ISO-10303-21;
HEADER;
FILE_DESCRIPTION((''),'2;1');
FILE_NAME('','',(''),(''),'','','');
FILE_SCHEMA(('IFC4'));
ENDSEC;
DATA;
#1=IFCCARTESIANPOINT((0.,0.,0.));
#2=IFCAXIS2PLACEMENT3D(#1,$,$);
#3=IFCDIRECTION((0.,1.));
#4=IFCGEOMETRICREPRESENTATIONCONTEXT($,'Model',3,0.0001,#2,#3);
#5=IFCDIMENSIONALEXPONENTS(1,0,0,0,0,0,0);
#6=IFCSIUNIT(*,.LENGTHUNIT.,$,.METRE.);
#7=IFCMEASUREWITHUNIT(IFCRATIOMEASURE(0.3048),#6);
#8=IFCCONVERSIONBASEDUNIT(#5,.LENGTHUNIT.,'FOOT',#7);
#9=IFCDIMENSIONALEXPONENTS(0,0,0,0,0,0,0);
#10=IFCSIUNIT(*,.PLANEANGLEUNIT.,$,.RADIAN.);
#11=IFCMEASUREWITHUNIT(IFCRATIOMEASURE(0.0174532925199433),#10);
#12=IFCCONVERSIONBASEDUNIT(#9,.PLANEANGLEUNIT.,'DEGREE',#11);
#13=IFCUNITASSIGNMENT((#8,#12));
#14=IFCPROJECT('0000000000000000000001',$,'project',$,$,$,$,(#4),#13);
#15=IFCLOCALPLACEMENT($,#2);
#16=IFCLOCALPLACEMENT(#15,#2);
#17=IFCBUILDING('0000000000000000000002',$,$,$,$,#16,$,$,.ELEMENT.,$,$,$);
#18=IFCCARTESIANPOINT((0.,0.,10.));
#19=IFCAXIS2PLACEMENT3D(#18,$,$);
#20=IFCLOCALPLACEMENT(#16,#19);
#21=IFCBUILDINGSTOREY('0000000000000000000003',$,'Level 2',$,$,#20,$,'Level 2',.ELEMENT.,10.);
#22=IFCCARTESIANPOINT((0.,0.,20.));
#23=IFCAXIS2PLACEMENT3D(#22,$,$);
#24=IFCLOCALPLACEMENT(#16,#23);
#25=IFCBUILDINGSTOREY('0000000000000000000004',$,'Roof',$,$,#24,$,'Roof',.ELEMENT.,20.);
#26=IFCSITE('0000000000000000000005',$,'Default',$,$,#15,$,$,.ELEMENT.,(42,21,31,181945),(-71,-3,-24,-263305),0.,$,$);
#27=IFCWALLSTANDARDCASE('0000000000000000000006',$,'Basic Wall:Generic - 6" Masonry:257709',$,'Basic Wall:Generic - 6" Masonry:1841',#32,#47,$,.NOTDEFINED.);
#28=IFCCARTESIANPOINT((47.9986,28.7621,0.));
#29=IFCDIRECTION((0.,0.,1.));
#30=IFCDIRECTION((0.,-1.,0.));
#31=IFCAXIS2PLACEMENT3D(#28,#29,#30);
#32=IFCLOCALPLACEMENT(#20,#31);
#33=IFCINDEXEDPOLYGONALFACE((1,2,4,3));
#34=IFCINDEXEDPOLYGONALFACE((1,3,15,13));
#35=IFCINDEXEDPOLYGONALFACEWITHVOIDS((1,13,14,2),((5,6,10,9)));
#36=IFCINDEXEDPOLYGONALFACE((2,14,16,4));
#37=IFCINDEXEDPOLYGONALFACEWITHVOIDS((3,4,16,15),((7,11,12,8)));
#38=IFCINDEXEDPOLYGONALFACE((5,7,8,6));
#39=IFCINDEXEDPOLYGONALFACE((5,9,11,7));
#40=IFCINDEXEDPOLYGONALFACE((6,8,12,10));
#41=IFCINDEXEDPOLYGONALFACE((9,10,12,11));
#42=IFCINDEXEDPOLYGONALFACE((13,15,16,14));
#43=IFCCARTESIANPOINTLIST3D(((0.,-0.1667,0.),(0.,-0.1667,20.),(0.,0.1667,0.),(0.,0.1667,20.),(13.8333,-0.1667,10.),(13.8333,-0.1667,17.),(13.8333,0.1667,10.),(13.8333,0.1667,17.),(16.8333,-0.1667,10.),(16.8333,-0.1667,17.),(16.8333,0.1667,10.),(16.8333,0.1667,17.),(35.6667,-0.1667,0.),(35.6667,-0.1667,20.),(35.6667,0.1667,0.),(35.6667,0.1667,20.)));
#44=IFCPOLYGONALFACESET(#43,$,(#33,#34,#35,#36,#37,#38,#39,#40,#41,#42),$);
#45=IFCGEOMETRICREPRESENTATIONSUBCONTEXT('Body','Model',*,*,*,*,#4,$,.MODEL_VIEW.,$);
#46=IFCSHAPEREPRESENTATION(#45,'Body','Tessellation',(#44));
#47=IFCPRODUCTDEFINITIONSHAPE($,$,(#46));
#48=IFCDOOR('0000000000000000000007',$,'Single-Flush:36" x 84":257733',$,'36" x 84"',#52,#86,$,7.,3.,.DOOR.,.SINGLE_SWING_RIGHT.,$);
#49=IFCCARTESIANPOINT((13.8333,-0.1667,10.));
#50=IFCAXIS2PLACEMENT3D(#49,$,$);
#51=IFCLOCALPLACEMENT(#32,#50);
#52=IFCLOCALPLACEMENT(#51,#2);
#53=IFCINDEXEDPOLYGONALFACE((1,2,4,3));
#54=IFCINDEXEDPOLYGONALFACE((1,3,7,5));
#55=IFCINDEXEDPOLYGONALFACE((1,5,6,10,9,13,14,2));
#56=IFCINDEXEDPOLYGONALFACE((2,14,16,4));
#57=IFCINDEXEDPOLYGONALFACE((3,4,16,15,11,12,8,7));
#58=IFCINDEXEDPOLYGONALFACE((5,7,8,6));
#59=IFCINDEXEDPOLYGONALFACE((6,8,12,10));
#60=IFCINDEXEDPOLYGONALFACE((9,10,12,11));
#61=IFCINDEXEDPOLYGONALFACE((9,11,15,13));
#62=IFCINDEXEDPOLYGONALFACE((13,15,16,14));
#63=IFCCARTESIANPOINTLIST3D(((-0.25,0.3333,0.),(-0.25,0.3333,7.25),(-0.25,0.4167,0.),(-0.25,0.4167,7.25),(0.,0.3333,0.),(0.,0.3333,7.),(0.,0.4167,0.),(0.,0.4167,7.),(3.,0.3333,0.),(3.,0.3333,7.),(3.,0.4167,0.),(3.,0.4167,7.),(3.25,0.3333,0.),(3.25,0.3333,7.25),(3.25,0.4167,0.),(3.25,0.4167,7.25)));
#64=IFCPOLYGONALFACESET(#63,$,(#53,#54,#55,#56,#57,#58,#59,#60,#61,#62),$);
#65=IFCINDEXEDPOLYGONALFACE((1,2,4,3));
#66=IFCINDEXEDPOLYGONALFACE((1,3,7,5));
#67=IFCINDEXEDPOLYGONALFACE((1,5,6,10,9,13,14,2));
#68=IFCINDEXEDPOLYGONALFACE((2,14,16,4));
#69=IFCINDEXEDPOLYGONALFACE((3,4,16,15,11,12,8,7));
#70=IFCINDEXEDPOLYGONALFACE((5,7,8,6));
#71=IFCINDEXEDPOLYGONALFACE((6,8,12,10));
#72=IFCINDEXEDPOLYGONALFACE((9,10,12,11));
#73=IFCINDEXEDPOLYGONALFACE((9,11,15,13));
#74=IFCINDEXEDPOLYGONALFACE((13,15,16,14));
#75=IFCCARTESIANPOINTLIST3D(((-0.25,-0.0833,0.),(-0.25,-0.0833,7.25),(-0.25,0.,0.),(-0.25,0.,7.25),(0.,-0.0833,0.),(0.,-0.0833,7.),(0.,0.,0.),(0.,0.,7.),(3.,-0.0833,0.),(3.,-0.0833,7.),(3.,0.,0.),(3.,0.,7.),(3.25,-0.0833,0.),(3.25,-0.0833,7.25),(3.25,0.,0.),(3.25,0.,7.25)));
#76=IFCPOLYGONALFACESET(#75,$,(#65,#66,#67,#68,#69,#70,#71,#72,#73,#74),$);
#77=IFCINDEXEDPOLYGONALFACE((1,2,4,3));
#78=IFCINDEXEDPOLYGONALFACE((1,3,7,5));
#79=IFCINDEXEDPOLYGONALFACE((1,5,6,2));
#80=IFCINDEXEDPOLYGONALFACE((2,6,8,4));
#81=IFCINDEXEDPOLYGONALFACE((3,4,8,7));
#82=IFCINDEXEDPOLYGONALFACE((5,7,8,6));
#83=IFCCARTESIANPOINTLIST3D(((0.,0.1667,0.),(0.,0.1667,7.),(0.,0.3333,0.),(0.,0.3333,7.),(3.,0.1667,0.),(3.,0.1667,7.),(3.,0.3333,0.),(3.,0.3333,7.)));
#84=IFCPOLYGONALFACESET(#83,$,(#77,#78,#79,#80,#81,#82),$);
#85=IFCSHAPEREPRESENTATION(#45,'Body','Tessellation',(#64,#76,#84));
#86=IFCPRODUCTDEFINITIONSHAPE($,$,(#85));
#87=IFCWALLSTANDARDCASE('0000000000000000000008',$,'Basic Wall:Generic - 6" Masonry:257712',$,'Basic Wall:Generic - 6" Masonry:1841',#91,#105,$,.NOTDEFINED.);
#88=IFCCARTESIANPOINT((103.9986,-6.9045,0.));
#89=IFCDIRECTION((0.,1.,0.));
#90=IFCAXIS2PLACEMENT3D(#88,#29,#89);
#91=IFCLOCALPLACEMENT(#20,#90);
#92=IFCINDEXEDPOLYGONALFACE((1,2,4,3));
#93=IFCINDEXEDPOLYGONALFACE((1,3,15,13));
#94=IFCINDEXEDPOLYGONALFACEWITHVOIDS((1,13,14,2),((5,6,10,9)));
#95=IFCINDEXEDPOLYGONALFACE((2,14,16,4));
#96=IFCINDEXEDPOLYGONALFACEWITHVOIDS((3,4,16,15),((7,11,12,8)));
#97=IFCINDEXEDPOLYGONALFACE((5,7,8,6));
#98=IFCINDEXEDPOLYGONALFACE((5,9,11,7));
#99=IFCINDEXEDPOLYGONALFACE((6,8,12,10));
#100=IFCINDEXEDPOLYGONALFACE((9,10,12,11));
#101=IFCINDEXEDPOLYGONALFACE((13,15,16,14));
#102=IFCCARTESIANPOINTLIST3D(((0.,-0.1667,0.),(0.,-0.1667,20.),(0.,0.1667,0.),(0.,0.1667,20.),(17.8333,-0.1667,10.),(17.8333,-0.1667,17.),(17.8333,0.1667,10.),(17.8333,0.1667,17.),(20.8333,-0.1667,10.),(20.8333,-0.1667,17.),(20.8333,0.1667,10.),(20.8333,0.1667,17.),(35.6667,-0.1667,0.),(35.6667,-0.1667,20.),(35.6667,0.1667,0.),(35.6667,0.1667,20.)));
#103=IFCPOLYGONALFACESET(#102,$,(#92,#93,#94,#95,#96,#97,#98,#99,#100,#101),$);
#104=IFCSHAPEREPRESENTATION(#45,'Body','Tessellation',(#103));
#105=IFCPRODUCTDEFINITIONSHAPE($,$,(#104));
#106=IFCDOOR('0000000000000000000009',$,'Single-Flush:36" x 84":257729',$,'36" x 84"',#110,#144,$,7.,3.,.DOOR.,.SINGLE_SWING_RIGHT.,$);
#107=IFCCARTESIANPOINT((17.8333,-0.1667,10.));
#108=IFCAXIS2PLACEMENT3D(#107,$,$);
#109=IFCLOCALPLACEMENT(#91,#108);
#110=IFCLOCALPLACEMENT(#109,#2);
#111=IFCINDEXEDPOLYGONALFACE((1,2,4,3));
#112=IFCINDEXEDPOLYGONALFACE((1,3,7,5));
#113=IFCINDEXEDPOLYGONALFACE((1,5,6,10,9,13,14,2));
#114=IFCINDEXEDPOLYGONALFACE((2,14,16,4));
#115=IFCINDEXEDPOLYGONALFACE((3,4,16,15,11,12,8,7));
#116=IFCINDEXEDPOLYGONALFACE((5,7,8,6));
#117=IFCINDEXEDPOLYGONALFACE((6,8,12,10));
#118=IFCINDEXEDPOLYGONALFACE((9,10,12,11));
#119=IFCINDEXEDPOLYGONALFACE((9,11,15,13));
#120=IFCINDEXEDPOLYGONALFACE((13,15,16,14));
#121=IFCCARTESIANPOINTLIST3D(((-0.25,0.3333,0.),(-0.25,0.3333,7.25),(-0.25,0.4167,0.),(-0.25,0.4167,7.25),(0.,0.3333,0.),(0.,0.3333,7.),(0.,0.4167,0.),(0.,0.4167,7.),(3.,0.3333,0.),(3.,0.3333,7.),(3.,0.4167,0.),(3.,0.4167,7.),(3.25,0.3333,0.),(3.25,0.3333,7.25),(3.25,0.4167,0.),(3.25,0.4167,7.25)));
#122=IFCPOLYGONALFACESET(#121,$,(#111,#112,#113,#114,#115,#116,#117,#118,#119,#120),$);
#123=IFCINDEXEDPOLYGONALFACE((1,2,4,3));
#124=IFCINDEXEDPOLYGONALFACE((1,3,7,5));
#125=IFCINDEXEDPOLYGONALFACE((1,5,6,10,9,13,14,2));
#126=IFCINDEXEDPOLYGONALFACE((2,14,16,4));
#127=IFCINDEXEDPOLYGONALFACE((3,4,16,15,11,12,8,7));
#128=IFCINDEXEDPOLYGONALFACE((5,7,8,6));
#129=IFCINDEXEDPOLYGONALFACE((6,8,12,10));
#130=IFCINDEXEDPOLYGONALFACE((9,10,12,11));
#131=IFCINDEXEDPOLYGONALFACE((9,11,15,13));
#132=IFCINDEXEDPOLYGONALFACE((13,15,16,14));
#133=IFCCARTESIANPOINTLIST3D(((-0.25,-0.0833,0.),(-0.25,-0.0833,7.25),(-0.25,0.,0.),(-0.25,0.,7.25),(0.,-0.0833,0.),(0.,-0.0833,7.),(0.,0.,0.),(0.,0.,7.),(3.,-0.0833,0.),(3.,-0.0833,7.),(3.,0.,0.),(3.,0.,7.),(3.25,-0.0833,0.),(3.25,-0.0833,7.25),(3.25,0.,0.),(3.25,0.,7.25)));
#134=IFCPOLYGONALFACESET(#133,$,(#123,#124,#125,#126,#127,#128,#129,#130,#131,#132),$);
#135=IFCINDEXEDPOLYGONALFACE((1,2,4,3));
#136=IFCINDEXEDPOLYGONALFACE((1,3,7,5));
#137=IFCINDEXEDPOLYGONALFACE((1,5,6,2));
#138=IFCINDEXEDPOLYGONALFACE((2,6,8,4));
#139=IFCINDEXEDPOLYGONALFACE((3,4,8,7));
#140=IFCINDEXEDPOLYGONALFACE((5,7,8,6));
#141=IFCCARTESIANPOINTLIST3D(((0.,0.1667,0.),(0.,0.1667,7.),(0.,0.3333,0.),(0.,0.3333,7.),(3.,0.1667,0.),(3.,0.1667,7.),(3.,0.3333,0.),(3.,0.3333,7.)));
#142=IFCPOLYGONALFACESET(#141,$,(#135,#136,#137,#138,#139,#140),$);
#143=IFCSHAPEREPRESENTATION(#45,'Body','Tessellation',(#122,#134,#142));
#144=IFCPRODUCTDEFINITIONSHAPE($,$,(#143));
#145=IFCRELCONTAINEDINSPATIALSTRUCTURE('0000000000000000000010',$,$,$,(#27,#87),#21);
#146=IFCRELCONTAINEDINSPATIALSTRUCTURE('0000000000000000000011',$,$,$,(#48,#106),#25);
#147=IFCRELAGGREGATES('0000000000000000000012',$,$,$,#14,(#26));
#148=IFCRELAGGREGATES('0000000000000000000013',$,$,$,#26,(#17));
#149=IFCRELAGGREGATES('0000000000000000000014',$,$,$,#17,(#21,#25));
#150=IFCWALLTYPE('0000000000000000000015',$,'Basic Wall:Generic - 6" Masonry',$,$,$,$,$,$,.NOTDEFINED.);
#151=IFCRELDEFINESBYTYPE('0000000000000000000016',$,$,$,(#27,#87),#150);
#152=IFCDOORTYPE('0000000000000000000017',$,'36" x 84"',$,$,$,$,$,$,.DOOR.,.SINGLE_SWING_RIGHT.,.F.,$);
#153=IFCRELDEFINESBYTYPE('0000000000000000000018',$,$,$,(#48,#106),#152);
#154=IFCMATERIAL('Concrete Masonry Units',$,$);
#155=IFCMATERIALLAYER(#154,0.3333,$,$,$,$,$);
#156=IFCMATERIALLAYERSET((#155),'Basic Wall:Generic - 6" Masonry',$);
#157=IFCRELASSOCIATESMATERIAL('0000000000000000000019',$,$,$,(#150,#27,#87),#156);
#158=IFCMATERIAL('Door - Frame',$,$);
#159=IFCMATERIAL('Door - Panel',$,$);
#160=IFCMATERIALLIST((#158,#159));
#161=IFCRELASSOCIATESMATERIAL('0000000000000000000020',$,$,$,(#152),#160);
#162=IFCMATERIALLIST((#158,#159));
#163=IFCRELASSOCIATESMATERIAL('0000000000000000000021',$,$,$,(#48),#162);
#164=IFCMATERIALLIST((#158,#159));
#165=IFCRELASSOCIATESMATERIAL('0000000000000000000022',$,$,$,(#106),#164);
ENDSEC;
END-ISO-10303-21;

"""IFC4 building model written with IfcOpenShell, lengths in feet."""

from ifc_helpers import new_model, entity, si_unit, converted_unit, direction, frame, frame_2d, origin, place, context, subcontext, project, spatial, polyline, rectangle, outline, extrude, source, transform, mapped, material, material_list, layer, layer_set, layer_usage, type_object, type_shapes, element, fill, save


model = new_model("IFC4")

# Units and contexts
model_context = context("Model", 3, precision=0.0001, world=origin(), true_north=direction((0.0, 1.0)))
body_context = subcontext(model_context, "Body", "Model", "MODEL_VIEW")
ifc_project = project(units=[converted_unit("LENGTHUNIT", "FOOT", entity("IfcRatioMeasure", 0.3048), si_unit("LENGTHUNIT", "METRE"), dimensions=[1, 0, 0, 0, 0, 0, 0]), converted_unit("PLANEANGLEUNIT", "DEGREE", entity("IfcRatioMeasure", 0.0174532925199433), si_unit("PLANEANGLEUNIT", "RADIAN"), dimensions=[0, 0, 0, 0, 0, 0, 0])], contexts=[model_context])

# Site, building, storey
site_placement = place(None, origin())
site = spatial("IfcSite", under=ifc_project, at=site_placement, Name="Default", CompositionType="ELEMENT", RefLatitude=(42, 21, 31, 181945), RefLongitude=(-71, -3, -24, -263305), RefElevation=0.0)
building_placement = place(site_placement, origin())
building = spatial("IfcBuilding", under=site, at=building_placement, CompositionType="ELEMENT")
storey_1_placement = place(building_placement, frame((0.0, 0.0, 10.0)))
storey_1 = spatial("IfcBuildingStorey", under=building, at=storey_1_placement, Name="Level 2", LongName="Level 2", CompositionType="ELEMENT", Elevation=10.0)

# Wall, opening
ifc_material_1 = material(Name="Concrete Masonry Units")
ifc_layer = layer(ifc_material_1, 0.3333)
ifc_layer_set = layer_set([ifc_layer], Name="Basic Wall:Generic - 6\" Masonry")
ifc_layer_usage_1 = layer_usage(ifc_layer_set, "AXIS2", "NEGATIVE", 0.1667)
wall_type = type_object("IfcWallType", Name="Basic Wall:Generic - 6\" Masonry", PredefinedType="NOTDEFINED", material=ifc_layer_set)
wall_1_placement = place(storey_1_placement, frame((47.9986, 28.7621, 0.0), z_axis=(0.0, 0.0, 1.0), x_axis=(0.0, -1.0, 0.0)))
wall_1 = element("IfcWallStandardCase", 1, at=wall_1_placement, inside=storey_1, type_object=wall_type, material=ifc_layer_usage_1, Name="Basic Wall:Generic - 6\" Masonry:257709", ObjectType="Basic Wall:Generic - 6\" Masonry:1841", PredefinedType="NOTDEFINED", context=body_context, shape_type="SweptSolid", body=[
    extrude(rectangle(XDim=35.6667, YDim=0.3333, at=frame_2d((17.8333, 0.0), x_axis=(-1.0, 0.0))), origin(), (0.0, 0.0, 1.0), 20.0),
])
opening_1_placement = place(wall_1_placement, frame((13.8333, -0.1667, 10.0)))
opening_1 = element("IfcOpeningElement", 2, at=opening_1_placement, cuts=wall_1, ObjectType="Opening", PredefinedType="OPENING", context=body_context, shape_type="SweptSolid", body=[
    extrude(rectangle(XDim=3.0, YDim=7.0, at=frame_2d((3.5, 1.5), x_axis=(0.0, 1.0))), frame((0.0, 0.0, 0.0), z_axis=(0.0, 1.0, 0.0), x_axis=(0.0, 0.0, 1.0)), (0.0, 0.0, 1.0), 0.3333),
])

# Shared definitions
storey_2_placement = place(building_placement, frame((0.0, 0.0, 20.0)))
storey_2 = spatial("IfcBuildingStorey", under=building, at=storey_2_placement, Name="Roof", LongName="Roof", CompositionType="ELEMENT", Elevation=20.0)

# Door
ifc_material_2 = material(Name="Door - Frame")
ifc_material_3 = material(Name="Door - Panel")
ifc_material_list_1 = material_list([ifc_material_2, ifc_material_3])
ifc_material_list_2 = material_list([ifc_material_2, ifc_material_3])
door_type = type_object("IfcDoorType", Name="36\" x 84\"", OperationType="SINGLE_SWING_RIGHT", ParameterTakesPrecedence=False, PredefinedType="DOOR", material=ifc_material_list_2)
shared_shape_1 = source(origin(), body_context, "Body", "SweptSolid", [
    extrude(outline(polyline([(-1.75, -3.6875), (1.75, -3.6875), (1.75, 3.5625), (1.5, 3.5625), (1.5, -3.4375), (-1.5, -3.4375), (-1.5, 3.5625), (-1.75, 3.5625), (-1.75, -3.6875)])), frame((1.5, 0.3333, 3.5625), z_axis=(0.0, 1.0, 0.0), x_axis=(1.0, 0.0, 0.0)), (0.0, 0.0, 1.0), 0.0833),
    extrude(outline(polyline([(-3.6875, -1.75), (3.5625, -1.75), (3.5625, -1.5), (-3.4375, -1.5), (-3.4375, 1.5), (3.5625, 1.5), (3.5625, 1.75), (-3.6875, 1.75), (-3.6875, -1.75)])), frame((1.5, -0.0833, 3.5625), z_axis=(0.0, 1.0, 0.0), x_axis=(0.0, 0.0, -1.0)), (0.0, 0.0, 1.0), 0.0833),
    extrude(rectangle(XDim=0.1667, YDim=3.0, at=frame_2d((0.0, 0.0), x_axis=(1.0, 0.0))), frame((1.5, 0.25, 0.0), z_axis=(0.0, 0.0, 1.0), x_axis=(0.0, 1.0, 0.0)), (0.0, 0.0, 1.0), 7.0),
])
type_shapes(door_type, [shared_shape_1])
door_1_placement = place(opening_1_placement, origin())
door_1 = element("IfcDoor", 3, at=door_1_placement, inside=storey_2, type_object=door_type, material=ifc_material_list_1, Name="Single-Flush:36\" x 84\":257733", ObjectType="36\" x 84\"", OperationType="SINGLE_SWING_RIGHT", OverallHeight=7.0, OverallWidth=3.0, PredefinedType="DOOR", context=body_context, shape_type="MappedRepresentation", body=[
    mapped(shared_shape_1, transform((0.0, 0.0, 0.0), scale=1.0)),
])
fill(opening_1, door_1)

# Wall, opening, door
ifc_layer_usage_2 = layer_usage(ifc_layer_set, "AXIS2", "NEGATIVE", 0.1667)
wall_2_placement = place(storey_1_placement, frame((103.9986, -6.9045, 0.0), z_axis=(0.0, 0.0, 1.0), x_axis=(0.0, 1.0, 0.0)))
wall_2 = element("IfcWallStandardCase", 4, at=wall_2_placement, inside=storey_1, type_object=wall_type, material=ifc_layer_usage_2, Name="Basic Wall:Generic - 6\" Masonry:257712", ObjectType="Basic Wall:Generic - 6\" Masonry:1841", PredefinedType="NOTDEFINED", context=body_context, shape_type="SweptSolid", body=[
    extrude(rectangle(XDim=35.6667, YDim=0.3333, at=frame_2d((17.8333, 0.0), x_axis=(-1.0, 0.0))), origin(), (0.0, 0.0, 1.0), 20.0),
])
opening_2_placement = place(wall_2_placement, frame((17.8333, -0.1667, 10.0)))
opening_2 = element("IfcOpeningElement", 5, at=opening_2_placement, cuts=wall_2, ObjectType="Opening", PredefinedType="OPENING", context=body_context, shape_type="SweptSolid", body=[
    extrude(rectangle(XDim=3.0, YDim=7.0, at=frame_2d((3.5, 1.5), x_axis=(0.0, 1.0))), frame((0.0, 0.0, 0.0), z_axis=(0.0, 1.0, 0.0), x_axis=(0.0, 0.0, 1.0)), (0.0, 0.0, 1.0), 0.3333),
])
ifc_material_list_3 = material_list([ifc_material_2, ifc_material_3])
door_2_placement = place(opening_2_placement, origin())
door_2 = element("IfcDoor", 6, at=door_2_placement, inside=storey_2, type_object=door_type, material=ifc_material_list_3, Name="Single-Flush:36\" x 84\":257729", ObjectType="36\" x 84\"", OperationType="SINGLE_SWING_RIGHT", OverallHeight=7.0, OverallWidth=3.0, PredefinedType="DOOR", context=body_context, shape_type="MappedRepresentation", body=[
    mapped(shared_shape_1, transform((0.0, 0.0, 0.0), scale=1.0)),
])
fill(opening_2, door_2)

save(model, "model.ifc")
